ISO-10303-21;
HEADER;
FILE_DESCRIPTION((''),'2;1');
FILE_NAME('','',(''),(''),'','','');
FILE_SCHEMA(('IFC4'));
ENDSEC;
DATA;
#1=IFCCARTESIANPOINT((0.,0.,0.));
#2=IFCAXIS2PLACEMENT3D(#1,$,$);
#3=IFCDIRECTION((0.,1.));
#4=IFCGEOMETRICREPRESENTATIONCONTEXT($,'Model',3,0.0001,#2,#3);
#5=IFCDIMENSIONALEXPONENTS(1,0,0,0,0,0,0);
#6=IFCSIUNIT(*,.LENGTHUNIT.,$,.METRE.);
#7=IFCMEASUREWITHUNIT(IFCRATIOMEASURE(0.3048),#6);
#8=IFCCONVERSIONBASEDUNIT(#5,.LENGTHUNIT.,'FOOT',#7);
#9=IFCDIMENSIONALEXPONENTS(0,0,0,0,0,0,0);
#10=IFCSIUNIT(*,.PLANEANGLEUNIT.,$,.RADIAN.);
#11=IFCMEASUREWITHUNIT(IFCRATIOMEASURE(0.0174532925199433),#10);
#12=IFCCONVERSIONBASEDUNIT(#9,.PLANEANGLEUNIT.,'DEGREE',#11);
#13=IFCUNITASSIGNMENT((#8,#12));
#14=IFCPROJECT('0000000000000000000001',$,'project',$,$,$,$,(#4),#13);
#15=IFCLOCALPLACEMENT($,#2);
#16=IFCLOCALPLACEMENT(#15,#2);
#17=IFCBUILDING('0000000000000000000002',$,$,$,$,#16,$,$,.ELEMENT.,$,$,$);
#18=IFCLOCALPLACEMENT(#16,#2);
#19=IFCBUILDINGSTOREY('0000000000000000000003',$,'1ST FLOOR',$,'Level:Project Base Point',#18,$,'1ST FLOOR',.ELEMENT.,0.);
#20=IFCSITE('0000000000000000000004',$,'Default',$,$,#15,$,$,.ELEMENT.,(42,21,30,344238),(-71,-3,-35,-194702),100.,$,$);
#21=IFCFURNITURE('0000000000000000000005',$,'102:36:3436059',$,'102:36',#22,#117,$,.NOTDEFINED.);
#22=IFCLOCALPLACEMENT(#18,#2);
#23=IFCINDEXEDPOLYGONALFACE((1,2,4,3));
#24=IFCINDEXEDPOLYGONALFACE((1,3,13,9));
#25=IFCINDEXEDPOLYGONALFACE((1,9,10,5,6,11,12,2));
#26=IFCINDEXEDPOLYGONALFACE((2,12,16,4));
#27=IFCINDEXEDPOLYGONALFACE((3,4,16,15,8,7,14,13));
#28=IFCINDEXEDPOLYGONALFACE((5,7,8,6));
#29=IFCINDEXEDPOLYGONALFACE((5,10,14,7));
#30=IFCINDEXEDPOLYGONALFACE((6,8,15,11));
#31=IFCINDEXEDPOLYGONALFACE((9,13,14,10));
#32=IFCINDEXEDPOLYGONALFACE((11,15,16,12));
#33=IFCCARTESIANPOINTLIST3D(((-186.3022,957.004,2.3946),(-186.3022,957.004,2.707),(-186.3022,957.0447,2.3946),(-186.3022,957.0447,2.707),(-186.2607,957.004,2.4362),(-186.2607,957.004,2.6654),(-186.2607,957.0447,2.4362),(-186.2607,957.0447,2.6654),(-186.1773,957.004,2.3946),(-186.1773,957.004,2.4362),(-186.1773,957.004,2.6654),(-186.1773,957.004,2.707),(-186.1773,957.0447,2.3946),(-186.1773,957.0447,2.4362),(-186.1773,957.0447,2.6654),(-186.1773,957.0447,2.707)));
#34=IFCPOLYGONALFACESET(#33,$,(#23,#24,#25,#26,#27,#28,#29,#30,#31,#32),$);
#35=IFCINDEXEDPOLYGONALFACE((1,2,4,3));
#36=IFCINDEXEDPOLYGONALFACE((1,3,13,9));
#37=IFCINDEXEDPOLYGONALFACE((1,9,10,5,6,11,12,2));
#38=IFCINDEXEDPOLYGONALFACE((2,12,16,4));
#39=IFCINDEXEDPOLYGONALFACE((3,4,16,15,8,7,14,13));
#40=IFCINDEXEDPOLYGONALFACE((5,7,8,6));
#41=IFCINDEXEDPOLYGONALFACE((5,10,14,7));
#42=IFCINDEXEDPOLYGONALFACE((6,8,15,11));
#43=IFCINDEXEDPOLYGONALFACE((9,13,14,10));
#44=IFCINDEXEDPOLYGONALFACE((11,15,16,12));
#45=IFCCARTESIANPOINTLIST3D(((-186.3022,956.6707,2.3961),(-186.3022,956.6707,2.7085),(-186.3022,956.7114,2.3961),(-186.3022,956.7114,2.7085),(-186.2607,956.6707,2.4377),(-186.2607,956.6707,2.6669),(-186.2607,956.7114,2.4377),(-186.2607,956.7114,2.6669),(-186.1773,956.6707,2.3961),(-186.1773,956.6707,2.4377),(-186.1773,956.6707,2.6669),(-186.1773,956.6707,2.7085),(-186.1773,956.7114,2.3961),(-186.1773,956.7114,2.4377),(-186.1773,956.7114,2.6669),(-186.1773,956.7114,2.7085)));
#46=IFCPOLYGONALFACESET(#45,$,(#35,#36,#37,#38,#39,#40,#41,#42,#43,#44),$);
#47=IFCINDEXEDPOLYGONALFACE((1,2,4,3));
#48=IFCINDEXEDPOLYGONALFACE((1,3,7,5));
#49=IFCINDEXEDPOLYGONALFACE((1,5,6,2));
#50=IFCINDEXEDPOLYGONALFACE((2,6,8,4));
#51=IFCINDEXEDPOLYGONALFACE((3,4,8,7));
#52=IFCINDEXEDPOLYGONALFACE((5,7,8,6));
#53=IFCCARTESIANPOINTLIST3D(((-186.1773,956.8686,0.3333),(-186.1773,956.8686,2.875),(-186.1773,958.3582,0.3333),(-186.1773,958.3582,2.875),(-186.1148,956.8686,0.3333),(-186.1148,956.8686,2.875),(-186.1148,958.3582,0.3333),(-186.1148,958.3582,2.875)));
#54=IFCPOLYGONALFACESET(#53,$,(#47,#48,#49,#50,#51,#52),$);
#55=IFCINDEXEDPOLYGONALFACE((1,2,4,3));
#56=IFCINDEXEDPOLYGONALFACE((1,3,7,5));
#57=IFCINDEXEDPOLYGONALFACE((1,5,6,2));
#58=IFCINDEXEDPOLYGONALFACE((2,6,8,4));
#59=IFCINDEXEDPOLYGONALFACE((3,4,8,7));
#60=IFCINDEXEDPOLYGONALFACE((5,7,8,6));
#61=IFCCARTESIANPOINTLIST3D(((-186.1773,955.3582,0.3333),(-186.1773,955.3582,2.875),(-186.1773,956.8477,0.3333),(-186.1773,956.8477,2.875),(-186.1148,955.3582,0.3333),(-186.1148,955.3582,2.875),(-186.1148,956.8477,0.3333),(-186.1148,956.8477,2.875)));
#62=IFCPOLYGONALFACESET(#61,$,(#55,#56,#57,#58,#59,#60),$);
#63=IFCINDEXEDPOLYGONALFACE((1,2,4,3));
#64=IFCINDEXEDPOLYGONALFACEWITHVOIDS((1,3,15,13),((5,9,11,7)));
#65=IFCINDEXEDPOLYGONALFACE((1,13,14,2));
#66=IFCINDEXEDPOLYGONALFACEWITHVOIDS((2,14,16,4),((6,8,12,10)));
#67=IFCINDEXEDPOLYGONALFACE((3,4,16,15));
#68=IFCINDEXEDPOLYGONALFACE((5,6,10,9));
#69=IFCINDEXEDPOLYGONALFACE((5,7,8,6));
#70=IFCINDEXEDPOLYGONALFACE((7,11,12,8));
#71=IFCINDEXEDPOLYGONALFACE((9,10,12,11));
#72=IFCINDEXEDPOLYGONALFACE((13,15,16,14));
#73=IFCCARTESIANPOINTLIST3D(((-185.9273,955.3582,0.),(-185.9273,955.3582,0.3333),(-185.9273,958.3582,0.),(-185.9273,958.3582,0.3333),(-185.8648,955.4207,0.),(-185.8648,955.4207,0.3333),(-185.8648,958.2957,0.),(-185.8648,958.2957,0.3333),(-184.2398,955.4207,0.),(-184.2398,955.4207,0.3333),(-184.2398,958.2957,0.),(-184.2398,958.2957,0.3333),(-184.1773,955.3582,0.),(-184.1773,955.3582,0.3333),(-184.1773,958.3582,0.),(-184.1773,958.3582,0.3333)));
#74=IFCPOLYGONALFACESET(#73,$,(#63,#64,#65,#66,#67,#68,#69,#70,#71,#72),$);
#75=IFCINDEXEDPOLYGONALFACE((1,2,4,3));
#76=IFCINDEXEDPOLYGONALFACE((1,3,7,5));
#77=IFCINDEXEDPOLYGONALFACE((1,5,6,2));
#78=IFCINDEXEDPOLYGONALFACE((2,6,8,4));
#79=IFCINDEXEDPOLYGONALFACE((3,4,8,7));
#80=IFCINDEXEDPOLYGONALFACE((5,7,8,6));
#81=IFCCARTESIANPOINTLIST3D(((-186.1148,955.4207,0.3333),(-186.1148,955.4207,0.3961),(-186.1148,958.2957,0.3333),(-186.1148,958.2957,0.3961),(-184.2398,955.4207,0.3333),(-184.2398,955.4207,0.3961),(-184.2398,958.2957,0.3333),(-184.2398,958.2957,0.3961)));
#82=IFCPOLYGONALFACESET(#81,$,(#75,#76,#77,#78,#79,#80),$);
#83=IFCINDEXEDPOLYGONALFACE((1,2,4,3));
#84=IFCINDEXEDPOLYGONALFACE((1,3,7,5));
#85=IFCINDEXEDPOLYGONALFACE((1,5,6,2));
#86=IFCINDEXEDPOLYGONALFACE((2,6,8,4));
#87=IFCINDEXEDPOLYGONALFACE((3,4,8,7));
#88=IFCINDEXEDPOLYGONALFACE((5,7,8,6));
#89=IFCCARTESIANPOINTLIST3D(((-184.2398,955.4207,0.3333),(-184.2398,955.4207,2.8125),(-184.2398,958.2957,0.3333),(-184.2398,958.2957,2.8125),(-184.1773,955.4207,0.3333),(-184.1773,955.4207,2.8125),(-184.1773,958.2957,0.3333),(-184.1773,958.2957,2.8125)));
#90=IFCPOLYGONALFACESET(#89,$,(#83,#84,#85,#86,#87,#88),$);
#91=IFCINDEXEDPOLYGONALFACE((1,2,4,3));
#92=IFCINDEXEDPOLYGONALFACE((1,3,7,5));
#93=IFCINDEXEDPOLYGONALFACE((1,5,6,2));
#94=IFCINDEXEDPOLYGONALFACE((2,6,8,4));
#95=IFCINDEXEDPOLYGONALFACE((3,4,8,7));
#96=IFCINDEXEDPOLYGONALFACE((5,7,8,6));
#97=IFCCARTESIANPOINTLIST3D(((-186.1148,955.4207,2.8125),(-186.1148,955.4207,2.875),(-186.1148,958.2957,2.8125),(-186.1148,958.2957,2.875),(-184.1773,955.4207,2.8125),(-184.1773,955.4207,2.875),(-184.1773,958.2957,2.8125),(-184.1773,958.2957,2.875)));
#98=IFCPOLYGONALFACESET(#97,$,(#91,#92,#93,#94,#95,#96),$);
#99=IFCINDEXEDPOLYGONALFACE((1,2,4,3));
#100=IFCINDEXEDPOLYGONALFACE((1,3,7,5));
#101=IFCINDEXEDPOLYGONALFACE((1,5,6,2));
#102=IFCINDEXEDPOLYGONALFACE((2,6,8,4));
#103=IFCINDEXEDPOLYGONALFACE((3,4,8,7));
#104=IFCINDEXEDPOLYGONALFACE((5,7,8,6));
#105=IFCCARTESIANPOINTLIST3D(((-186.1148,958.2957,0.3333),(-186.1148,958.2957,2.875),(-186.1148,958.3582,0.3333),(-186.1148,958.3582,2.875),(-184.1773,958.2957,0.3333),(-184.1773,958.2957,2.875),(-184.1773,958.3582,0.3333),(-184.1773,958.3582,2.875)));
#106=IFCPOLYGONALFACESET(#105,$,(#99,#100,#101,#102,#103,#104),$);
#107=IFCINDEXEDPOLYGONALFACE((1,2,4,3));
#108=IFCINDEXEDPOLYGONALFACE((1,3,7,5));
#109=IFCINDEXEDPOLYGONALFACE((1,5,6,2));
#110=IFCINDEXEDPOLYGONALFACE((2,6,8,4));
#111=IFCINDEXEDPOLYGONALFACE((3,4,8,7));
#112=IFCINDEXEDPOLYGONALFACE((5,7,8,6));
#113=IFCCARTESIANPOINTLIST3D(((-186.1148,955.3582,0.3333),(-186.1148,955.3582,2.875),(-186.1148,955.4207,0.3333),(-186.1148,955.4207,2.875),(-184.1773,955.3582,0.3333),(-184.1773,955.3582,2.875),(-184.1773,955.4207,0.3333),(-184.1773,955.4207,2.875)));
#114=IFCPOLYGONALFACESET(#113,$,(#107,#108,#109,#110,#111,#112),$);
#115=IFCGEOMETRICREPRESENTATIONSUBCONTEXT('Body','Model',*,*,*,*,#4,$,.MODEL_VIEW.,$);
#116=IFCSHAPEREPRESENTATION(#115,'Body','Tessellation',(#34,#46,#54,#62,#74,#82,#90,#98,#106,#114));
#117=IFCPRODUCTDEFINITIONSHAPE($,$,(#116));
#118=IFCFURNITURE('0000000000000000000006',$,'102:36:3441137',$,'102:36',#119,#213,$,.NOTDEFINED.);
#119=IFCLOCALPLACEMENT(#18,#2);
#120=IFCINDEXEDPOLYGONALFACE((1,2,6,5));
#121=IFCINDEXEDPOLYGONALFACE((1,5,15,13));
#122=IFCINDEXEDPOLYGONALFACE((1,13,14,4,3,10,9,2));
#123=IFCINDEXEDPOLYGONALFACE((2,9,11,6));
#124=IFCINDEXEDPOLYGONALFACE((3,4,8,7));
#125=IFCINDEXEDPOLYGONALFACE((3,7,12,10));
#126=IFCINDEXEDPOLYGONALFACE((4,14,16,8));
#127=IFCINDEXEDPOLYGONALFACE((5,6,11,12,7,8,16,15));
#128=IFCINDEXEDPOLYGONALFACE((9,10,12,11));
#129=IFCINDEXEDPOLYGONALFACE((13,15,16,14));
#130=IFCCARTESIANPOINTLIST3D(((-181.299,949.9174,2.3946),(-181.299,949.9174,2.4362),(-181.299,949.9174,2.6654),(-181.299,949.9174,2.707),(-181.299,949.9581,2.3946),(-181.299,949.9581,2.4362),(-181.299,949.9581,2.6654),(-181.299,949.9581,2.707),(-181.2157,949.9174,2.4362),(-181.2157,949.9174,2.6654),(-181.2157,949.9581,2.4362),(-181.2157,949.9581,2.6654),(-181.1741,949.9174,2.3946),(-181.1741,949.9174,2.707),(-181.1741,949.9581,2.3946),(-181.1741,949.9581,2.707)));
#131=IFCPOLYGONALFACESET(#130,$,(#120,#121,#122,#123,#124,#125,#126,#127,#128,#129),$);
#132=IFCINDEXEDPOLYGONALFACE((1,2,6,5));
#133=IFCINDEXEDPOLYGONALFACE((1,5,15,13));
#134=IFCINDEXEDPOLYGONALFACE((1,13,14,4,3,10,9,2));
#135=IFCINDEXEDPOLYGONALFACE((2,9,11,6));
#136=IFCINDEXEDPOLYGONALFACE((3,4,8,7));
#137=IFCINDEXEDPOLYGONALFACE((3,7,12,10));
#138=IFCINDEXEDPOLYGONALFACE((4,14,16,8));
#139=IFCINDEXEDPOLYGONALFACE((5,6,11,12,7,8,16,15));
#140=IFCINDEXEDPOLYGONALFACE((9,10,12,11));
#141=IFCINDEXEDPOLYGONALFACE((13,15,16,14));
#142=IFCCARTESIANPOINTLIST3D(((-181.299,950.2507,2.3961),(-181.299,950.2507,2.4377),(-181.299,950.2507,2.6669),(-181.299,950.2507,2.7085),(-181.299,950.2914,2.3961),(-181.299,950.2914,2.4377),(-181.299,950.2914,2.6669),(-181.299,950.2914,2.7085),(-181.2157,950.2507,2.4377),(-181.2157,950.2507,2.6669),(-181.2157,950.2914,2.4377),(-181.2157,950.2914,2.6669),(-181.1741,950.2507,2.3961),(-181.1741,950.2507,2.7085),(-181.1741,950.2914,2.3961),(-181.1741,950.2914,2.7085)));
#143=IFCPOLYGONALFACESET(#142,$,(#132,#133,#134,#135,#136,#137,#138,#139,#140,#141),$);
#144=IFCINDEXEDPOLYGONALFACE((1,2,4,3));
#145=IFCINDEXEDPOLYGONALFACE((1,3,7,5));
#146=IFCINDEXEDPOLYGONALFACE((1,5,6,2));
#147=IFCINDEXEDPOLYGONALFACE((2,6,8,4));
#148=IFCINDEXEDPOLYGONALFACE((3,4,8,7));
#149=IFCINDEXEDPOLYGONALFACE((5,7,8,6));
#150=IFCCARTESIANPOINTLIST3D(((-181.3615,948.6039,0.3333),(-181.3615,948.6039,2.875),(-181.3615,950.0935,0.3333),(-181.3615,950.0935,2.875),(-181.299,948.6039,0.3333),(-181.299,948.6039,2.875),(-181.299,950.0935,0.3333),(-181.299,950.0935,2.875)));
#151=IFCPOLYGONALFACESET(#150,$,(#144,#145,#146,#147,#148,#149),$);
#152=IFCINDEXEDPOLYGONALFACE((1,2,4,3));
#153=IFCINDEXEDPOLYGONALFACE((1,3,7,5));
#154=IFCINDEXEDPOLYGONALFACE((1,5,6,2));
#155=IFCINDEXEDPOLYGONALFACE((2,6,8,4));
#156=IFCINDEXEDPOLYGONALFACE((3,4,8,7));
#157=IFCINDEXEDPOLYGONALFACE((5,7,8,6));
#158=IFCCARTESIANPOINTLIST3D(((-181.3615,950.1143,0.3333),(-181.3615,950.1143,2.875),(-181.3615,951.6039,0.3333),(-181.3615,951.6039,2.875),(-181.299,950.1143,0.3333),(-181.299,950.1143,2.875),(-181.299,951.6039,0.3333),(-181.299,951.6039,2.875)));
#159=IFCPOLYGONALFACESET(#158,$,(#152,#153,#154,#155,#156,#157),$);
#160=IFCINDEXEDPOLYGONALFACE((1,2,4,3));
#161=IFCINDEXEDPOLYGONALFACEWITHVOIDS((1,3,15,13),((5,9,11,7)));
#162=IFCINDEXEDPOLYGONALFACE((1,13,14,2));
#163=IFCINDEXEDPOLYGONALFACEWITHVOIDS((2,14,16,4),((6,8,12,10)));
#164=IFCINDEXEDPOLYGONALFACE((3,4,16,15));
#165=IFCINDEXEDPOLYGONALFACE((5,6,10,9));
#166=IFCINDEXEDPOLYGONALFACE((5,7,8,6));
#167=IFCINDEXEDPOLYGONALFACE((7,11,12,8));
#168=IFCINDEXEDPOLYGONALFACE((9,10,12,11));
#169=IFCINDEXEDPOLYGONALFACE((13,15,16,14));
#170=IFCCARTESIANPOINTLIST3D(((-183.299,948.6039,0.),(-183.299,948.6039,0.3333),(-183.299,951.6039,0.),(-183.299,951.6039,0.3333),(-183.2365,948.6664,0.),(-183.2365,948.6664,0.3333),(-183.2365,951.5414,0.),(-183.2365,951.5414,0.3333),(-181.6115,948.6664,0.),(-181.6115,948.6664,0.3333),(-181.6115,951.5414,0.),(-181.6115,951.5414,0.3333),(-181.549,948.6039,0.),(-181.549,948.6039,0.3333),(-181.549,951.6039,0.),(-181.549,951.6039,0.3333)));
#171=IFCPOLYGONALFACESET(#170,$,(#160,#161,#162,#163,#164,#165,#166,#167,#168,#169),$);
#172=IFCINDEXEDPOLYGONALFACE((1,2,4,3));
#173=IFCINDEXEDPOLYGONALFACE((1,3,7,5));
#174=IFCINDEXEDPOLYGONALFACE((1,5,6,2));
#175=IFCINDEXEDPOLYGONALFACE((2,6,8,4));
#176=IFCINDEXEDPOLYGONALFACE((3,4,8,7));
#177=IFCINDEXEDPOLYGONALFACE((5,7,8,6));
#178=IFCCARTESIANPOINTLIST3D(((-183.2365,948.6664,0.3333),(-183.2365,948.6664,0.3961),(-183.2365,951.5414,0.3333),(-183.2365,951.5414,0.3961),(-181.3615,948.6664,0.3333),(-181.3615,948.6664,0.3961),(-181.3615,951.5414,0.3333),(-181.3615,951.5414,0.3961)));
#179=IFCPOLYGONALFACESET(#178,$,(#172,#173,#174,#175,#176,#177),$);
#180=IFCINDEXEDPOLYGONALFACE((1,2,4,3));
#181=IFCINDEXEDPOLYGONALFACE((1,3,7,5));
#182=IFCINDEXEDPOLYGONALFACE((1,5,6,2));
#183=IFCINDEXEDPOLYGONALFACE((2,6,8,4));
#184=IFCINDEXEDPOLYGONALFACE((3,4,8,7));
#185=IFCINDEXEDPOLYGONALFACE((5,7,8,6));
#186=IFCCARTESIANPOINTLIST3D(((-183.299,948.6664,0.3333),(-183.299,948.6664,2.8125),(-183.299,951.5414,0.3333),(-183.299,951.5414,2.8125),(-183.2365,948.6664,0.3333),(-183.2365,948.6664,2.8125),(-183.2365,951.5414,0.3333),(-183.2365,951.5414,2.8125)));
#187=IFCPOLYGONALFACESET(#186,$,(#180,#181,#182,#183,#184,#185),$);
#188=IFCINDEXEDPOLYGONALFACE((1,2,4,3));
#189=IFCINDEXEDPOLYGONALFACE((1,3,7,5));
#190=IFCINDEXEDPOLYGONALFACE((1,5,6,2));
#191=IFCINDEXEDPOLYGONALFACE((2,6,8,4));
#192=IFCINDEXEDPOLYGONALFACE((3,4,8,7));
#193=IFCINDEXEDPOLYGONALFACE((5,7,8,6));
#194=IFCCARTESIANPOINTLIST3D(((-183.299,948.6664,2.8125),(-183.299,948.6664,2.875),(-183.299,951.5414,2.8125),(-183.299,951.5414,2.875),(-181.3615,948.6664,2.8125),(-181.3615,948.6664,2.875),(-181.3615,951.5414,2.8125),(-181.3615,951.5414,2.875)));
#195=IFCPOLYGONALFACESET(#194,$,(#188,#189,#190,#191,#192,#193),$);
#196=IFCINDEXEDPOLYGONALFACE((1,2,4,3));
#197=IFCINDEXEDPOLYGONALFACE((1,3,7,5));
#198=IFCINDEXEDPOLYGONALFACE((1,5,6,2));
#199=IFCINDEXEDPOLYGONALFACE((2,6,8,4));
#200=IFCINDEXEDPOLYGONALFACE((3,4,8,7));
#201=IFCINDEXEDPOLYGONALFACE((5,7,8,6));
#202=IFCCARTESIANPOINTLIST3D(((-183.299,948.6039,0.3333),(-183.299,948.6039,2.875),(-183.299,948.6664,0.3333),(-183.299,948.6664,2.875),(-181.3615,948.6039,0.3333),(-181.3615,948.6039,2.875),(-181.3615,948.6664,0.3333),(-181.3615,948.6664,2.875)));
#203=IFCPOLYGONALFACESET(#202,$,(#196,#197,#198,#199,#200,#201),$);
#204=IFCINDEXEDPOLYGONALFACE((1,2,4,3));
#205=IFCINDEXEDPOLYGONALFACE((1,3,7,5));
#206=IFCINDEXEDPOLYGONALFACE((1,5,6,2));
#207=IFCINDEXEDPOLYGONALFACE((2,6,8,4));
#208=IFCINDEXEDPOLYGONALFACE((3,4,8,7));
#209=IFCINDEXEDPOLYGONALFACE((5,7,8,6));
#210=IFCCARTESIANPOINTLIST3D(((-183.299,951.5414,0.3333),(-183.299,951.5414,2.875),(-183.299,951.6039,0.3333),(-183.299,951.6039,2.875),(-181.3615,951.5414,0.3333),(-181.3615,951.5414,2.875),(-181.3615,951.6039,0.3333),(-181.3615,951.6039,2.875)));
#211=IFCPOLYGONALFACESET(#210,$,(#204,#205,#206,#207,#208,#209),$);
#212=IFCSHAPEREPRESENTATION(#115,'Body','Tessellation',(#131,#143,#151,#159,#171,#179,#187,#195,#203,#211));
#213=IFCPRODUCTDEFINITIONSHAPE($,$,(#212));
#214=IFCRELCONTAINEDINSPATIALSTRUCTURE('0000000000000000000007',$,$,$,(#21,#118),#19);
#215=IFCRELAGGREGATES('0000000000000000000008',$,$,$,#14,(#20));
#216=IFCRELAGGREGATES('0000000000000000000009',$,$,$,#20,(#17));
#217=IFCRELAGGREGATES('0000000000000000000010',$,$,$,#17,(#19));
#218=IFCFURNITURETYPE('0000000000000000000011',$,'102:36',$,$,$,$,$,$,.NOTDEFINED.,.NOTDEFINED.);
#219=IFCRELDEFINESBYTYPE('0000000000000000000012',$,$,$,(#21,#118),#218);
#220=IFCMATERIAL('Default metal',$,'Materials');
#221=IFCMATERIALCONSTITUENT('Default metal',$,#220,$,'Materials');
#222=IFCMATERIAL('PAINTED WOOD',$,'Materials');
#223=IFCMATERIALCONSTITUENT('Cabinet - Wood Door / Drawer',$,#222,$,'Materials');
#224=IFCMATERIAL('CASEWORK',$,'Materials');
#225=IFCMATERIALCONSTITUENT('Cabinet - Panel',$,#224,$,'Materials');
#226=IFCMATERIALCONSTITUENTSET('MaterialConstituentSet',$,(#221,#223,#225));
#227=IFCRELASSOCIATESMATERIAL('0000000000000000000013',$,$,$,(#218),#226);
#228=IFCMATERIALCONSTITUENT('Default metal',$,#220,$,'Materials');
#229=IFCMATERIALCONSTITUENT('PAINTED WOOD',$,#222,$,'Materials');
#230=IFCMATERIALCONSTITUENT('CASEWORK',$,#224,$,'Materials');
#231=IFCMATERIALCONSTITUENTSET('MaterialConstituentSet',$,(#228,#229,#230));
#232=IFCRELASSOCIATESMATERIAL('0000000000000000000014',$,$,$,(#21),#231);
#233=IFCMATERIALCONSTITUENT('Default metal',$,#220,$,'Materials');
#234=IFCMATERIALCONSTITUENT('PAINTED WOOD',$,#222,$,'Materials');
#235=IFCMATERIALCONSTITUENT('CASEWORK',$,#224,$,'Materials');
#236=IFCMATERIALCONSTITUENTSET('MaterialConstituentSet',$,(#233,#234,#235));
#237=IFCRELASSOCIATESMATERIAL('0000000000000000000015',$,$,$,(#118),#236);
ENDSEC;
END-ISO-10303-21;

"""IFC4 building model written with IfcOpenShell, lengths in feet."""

from ifc_helpers import new_model, entity, si_unit, converted_unit, direction, frame, frame_2d, origin, origin_2d_with_axis, place, context, subcontext, project, spatial, polyline, rectangle, outline, extrude, source, transform, mapped, material, constituent, constituent_set, type_object, type_shapes, element, save


model = new_model("IFC4")

# Units and contexts
model_context = context("Model", 3, precision=0.0001, world=origin(), true_north=direction((0.0, 1.0)))
body_context = subcontext(model_context, "Body", "Model", "MODEL_VIEW")
ifc_project = project(units=[converted_unit("LENGTHUNIT", "FOOT", entity("IfcRatioMeasure", 0.3048), si_unit("LENGTHUNIT", "METRE"), dimensions=[1, 0, 0, 0, 0, 0, 0]), converted_unit("PLANEANGLEUNIT", "DEGREE", entity("IfcRatioMeasure", 0.0174532925199433), si_unit("PLANEANGLEUNIT", "RADIAN"), dimensions=[0, 0, 0, 0, 0, 0, 0])], contexts=[model_context])

# Site, building, storey
site_placement = place(None, origin())
site = spatial("IfcSite", under=ifc_project, at=site_placement, Name="Default", CompositionType="ELEMENT", RefLatitude=(42, 21, 30, 344238), RefLongitude=(-71, -3, -35, -194702), RefElevation=100.0)
building_placement = place(site_placement, origin())
building = spatial("IfcBuilding", under=site, at=building_placement, CompositionType="ELEMENT")
storey_placement = place(building_placement, origin())
storey = spatial("IfcBuildingStorey", under=building, at=storey_placement, Name="1ST FLOOR", ObjectType="Level:Project Base Point", LongName="1ST FLOOR", CompositionType="ELEMENT", Elevation=0.0)

# Shared definitions
ifc_material_1 = material(Name="CASEWORK", Category="Materials")

# Furniture
ifc_material_2 = material(Name="Default metal", Category="Materials")
ifc_material_3 = material(Name="PAINTED WOOD", Category="Materials")
ifc_constituent_1 = constituent(ifc_material_2, Name="Default metal", Category="Materials")
ifc_constituent_2 = constituent(ifc_material_3, Name="PAINTED WOOD", Category="Materials")
ifc_constituent_3 = constituent(ifc_material_1, Name="CASEWORK", Category="Materials")
ifc_constituent_set_1 = constituent_set(constituents=[ifc_constituent_1, ifc_constituent_2, ifc_constituent_3], Name="MaterialConstituentSet")
ifc_constituent_4 = constituent(ifc_material_2, Name="Default metal", Category="Materials")
ifc_constituent_5 = constituent(ifc_material_3, Name="Cabinet - Wood Door / Drawer", Category="Materials")
ifc_constituent_6 = constituent(ifc_material_1, Name="Cabinet - Panel", Category="Materials")
ifc_constituent_set_2 = constituent_set(constituents=[ifc_constituent_4, ifc_constituent_5, ifc_constituent_6], Name="MaterialConstituentSet")
furniture_type_1 = type_object("IfcFurnitureType", Name="102:36", AssemblyPlace="NOTDEFINED", PredefinedType="NOTDEFINED", material=ifc_constituent_set_2)
shared_shape_1 = source(origin(), body_context, "Body", "SweptSolid", [
    extrude(outline(polyline([(-0.0521, -0.1146), (-0.0521, -0.1562), (0.0729, -0.1562), (0.0729, 0.1562), (-0.0521, 0.1562), (-0.0521, 0.1146), (0.0313, 0.1146), (0.0313, -0.1146), (-0.0521, -0.1146)])), frame((0.2073, 2.0521, 2.5508), z_axis=(-1.0, 0.0, 0.0), x_axis=(0.0, 1.0, 0.0)), (0.0, 0.0, -1.0), 0.0407),
    extrude(outline(polyline([(-0.0521, -0.1146), (-0.0521, -0.1562), (0.0729, -0.1562), (0.0729, 0.1562), (-0.0521, 0.1562), (-0.0521, 0.1146), (0.0313, 0.1146), (0.0313, -0.1146), (-0.0521, -0.1146)])), frame((-0.126, 2.0521, 2.5523), z_axis=(-1.0, 0.0, 0.0), x_axis=(0.0, 1.0, 0.0)), (0.0, 0.0, -1.0), 0.0407),
    extrude(rectangle(XDim=1.4896, YDim=0.0625, at=frame_2d((0.0, 0.0), x_axis=(1.0, 0.0))), frame((0.8167, 1.9688, 0.3333), z_axis=(0.0, 0.0, 1.0), x_axis=(-1.0, 0.0, 0.0)), (0.0, 0.0, 1.0), 2.5417),
    extrude(rectangle(XDim=1.4896, YDim=0.0625, at=origin_2d_with_axis()), frame((-0.6937, 1.9688, 0.3333), z_axis=(0.0, 0.0, 1.0), x_axis=(-1.0, 0.0, 0.0)), (0.0, 0.0, 1.0), 2.5417),
    extrude(outline(polyline([(-0.875, -1.5), (0.875, -1.5), (0.875, 1.5), (-0.875, 1.5), (-0.875, -1.5)]), holes=[polyline([(-0.8125, -1.4375), (-0.8125, 1.4375), (0.8125, 1.4375), (0.8125, -1.4375), (-0.8125, -1.4375)])]), frame((0.0615, 0.875, 0.0), z_axis=(0.0, 0.0, 1.0), x_axis=(0.0, -1.0, 0.0)), (0.0, 0.0, 1.0), 0.3333),
    extrude(rectangle(XDim=1.875, YDim=2.875, at=origin_2d_with_axis()), frame((0.0615, 1.0, 0.3333), z_axis=(0.0, 0.0, 1.0), x_axis=(0.0, 1.0, 0.0)), (0.0, 0.0, 1.0), 0.0627),
    extrude(rectangle(XDim=2.875, YDim=0.0625, at=origin_2d_with_axis()), frame((0.0615, 0.0312, 0.3333), z_axis=(0.0, 0.0, 1.0), x_axis=(-1.0, 0.0, 0.0)), (0.0, 0.0, 1.0), 2.4792),
    extrude(rectangle(XDim=1.9375, YDim=2.875, at=frame_2d((0.0, 0.0), x_axis=(1.0, 0.0))), frame((0.0615, 0.9688, 2.8125), z_axis=(0.0, 0.0, 1.0), x_axis=(0.0, 1.0, 0.0)), (0.0, 0.0, 1.0), 0.0625),
    extrude(rectangle(XDim=1.9375, YDim=0.0625, at=frame_2d((0.0, 0.0), x_axis=(1.0, 0.0))), frame((1.5302, 0.9687, 0.3333), z_axis=(0.0, 0.0, 1.0), x_axis=(0.0, -1.0, 0.0)), (0.0, 0.0, 1.0), 2.5417),
    extrude(rectangle(XDim=1.9375, YDim=0.0625, at=frame_2d((0.0, 0.0), x_axis=(1.0, 0.0))), frame((-1.4073, 0.9687, 0.3333), z_axis=(0.0, 0.0, 1.0), x_axis=(0.0, -1.0, 0.0)), (0.0, 0.0, 1.0), 2.5417),
])
type_shapes(furniture_type_1, [shared_shape_1])
furniture_1_placement = place(storey_placement, frame((-184.1773, 956.7967, 0.0), z_axis=(0.0, 0.0, 1.0), x_axis=(0.0, 1.0, 0.0)))
element("IfcFurniture", 1, at=furniture_1_placement, inside=storey, type_object=furniture_type_1, material=ifc_constituent_set_1, Name="102:36:3436059", ObjectType="102:36", PredefinedType="NOTDEFINED", context=body_context, shape_type="MappedRepresentation", body=[
    mapped(shared_shape_1, transform((0.0, 0.0, 0.0), scale=1.0)),
])
ifc_constituent_7 = constituent(ifc_material_2, Name="Default metal", Category="Materials")
ifc_constituent_8 = constituent(ifc_material_3, Name="PAINTED WOOD", Category="Materials")
ifc_constituent_9 = constituent(ifc_material_1, Name="CASEWORK", Category="Materials")
ifc_constituent_set_3 = constituent_set(constituents=[ifc_constituent_7, ifc_constituent_8, ifc_constituent_9], Name="MaterialConstituentSet")
furniture_2_placement = place(storey_placement, frame((-183.299, 950.1654, 0.0), z_axis=(0.0, 0.0, 1.0), x_axis=(0.0, -1.0, 0.0)))
element("IfcFurniture", 2, at=furniture_2_placement, inside=storey, type_object=furniture_type_1, material=ifc_constituent_set_3, Name="102:36:3441137", ObjectType="102:36", PredefinedType="NOTDEFINED", context=body_context, shape_type="MappedRepresentation", body=[
    mapped(shared_shape_1, transform((0.0, 0.0, 0.0), scale=1.0)),
])

save(model, "model.ifc")
